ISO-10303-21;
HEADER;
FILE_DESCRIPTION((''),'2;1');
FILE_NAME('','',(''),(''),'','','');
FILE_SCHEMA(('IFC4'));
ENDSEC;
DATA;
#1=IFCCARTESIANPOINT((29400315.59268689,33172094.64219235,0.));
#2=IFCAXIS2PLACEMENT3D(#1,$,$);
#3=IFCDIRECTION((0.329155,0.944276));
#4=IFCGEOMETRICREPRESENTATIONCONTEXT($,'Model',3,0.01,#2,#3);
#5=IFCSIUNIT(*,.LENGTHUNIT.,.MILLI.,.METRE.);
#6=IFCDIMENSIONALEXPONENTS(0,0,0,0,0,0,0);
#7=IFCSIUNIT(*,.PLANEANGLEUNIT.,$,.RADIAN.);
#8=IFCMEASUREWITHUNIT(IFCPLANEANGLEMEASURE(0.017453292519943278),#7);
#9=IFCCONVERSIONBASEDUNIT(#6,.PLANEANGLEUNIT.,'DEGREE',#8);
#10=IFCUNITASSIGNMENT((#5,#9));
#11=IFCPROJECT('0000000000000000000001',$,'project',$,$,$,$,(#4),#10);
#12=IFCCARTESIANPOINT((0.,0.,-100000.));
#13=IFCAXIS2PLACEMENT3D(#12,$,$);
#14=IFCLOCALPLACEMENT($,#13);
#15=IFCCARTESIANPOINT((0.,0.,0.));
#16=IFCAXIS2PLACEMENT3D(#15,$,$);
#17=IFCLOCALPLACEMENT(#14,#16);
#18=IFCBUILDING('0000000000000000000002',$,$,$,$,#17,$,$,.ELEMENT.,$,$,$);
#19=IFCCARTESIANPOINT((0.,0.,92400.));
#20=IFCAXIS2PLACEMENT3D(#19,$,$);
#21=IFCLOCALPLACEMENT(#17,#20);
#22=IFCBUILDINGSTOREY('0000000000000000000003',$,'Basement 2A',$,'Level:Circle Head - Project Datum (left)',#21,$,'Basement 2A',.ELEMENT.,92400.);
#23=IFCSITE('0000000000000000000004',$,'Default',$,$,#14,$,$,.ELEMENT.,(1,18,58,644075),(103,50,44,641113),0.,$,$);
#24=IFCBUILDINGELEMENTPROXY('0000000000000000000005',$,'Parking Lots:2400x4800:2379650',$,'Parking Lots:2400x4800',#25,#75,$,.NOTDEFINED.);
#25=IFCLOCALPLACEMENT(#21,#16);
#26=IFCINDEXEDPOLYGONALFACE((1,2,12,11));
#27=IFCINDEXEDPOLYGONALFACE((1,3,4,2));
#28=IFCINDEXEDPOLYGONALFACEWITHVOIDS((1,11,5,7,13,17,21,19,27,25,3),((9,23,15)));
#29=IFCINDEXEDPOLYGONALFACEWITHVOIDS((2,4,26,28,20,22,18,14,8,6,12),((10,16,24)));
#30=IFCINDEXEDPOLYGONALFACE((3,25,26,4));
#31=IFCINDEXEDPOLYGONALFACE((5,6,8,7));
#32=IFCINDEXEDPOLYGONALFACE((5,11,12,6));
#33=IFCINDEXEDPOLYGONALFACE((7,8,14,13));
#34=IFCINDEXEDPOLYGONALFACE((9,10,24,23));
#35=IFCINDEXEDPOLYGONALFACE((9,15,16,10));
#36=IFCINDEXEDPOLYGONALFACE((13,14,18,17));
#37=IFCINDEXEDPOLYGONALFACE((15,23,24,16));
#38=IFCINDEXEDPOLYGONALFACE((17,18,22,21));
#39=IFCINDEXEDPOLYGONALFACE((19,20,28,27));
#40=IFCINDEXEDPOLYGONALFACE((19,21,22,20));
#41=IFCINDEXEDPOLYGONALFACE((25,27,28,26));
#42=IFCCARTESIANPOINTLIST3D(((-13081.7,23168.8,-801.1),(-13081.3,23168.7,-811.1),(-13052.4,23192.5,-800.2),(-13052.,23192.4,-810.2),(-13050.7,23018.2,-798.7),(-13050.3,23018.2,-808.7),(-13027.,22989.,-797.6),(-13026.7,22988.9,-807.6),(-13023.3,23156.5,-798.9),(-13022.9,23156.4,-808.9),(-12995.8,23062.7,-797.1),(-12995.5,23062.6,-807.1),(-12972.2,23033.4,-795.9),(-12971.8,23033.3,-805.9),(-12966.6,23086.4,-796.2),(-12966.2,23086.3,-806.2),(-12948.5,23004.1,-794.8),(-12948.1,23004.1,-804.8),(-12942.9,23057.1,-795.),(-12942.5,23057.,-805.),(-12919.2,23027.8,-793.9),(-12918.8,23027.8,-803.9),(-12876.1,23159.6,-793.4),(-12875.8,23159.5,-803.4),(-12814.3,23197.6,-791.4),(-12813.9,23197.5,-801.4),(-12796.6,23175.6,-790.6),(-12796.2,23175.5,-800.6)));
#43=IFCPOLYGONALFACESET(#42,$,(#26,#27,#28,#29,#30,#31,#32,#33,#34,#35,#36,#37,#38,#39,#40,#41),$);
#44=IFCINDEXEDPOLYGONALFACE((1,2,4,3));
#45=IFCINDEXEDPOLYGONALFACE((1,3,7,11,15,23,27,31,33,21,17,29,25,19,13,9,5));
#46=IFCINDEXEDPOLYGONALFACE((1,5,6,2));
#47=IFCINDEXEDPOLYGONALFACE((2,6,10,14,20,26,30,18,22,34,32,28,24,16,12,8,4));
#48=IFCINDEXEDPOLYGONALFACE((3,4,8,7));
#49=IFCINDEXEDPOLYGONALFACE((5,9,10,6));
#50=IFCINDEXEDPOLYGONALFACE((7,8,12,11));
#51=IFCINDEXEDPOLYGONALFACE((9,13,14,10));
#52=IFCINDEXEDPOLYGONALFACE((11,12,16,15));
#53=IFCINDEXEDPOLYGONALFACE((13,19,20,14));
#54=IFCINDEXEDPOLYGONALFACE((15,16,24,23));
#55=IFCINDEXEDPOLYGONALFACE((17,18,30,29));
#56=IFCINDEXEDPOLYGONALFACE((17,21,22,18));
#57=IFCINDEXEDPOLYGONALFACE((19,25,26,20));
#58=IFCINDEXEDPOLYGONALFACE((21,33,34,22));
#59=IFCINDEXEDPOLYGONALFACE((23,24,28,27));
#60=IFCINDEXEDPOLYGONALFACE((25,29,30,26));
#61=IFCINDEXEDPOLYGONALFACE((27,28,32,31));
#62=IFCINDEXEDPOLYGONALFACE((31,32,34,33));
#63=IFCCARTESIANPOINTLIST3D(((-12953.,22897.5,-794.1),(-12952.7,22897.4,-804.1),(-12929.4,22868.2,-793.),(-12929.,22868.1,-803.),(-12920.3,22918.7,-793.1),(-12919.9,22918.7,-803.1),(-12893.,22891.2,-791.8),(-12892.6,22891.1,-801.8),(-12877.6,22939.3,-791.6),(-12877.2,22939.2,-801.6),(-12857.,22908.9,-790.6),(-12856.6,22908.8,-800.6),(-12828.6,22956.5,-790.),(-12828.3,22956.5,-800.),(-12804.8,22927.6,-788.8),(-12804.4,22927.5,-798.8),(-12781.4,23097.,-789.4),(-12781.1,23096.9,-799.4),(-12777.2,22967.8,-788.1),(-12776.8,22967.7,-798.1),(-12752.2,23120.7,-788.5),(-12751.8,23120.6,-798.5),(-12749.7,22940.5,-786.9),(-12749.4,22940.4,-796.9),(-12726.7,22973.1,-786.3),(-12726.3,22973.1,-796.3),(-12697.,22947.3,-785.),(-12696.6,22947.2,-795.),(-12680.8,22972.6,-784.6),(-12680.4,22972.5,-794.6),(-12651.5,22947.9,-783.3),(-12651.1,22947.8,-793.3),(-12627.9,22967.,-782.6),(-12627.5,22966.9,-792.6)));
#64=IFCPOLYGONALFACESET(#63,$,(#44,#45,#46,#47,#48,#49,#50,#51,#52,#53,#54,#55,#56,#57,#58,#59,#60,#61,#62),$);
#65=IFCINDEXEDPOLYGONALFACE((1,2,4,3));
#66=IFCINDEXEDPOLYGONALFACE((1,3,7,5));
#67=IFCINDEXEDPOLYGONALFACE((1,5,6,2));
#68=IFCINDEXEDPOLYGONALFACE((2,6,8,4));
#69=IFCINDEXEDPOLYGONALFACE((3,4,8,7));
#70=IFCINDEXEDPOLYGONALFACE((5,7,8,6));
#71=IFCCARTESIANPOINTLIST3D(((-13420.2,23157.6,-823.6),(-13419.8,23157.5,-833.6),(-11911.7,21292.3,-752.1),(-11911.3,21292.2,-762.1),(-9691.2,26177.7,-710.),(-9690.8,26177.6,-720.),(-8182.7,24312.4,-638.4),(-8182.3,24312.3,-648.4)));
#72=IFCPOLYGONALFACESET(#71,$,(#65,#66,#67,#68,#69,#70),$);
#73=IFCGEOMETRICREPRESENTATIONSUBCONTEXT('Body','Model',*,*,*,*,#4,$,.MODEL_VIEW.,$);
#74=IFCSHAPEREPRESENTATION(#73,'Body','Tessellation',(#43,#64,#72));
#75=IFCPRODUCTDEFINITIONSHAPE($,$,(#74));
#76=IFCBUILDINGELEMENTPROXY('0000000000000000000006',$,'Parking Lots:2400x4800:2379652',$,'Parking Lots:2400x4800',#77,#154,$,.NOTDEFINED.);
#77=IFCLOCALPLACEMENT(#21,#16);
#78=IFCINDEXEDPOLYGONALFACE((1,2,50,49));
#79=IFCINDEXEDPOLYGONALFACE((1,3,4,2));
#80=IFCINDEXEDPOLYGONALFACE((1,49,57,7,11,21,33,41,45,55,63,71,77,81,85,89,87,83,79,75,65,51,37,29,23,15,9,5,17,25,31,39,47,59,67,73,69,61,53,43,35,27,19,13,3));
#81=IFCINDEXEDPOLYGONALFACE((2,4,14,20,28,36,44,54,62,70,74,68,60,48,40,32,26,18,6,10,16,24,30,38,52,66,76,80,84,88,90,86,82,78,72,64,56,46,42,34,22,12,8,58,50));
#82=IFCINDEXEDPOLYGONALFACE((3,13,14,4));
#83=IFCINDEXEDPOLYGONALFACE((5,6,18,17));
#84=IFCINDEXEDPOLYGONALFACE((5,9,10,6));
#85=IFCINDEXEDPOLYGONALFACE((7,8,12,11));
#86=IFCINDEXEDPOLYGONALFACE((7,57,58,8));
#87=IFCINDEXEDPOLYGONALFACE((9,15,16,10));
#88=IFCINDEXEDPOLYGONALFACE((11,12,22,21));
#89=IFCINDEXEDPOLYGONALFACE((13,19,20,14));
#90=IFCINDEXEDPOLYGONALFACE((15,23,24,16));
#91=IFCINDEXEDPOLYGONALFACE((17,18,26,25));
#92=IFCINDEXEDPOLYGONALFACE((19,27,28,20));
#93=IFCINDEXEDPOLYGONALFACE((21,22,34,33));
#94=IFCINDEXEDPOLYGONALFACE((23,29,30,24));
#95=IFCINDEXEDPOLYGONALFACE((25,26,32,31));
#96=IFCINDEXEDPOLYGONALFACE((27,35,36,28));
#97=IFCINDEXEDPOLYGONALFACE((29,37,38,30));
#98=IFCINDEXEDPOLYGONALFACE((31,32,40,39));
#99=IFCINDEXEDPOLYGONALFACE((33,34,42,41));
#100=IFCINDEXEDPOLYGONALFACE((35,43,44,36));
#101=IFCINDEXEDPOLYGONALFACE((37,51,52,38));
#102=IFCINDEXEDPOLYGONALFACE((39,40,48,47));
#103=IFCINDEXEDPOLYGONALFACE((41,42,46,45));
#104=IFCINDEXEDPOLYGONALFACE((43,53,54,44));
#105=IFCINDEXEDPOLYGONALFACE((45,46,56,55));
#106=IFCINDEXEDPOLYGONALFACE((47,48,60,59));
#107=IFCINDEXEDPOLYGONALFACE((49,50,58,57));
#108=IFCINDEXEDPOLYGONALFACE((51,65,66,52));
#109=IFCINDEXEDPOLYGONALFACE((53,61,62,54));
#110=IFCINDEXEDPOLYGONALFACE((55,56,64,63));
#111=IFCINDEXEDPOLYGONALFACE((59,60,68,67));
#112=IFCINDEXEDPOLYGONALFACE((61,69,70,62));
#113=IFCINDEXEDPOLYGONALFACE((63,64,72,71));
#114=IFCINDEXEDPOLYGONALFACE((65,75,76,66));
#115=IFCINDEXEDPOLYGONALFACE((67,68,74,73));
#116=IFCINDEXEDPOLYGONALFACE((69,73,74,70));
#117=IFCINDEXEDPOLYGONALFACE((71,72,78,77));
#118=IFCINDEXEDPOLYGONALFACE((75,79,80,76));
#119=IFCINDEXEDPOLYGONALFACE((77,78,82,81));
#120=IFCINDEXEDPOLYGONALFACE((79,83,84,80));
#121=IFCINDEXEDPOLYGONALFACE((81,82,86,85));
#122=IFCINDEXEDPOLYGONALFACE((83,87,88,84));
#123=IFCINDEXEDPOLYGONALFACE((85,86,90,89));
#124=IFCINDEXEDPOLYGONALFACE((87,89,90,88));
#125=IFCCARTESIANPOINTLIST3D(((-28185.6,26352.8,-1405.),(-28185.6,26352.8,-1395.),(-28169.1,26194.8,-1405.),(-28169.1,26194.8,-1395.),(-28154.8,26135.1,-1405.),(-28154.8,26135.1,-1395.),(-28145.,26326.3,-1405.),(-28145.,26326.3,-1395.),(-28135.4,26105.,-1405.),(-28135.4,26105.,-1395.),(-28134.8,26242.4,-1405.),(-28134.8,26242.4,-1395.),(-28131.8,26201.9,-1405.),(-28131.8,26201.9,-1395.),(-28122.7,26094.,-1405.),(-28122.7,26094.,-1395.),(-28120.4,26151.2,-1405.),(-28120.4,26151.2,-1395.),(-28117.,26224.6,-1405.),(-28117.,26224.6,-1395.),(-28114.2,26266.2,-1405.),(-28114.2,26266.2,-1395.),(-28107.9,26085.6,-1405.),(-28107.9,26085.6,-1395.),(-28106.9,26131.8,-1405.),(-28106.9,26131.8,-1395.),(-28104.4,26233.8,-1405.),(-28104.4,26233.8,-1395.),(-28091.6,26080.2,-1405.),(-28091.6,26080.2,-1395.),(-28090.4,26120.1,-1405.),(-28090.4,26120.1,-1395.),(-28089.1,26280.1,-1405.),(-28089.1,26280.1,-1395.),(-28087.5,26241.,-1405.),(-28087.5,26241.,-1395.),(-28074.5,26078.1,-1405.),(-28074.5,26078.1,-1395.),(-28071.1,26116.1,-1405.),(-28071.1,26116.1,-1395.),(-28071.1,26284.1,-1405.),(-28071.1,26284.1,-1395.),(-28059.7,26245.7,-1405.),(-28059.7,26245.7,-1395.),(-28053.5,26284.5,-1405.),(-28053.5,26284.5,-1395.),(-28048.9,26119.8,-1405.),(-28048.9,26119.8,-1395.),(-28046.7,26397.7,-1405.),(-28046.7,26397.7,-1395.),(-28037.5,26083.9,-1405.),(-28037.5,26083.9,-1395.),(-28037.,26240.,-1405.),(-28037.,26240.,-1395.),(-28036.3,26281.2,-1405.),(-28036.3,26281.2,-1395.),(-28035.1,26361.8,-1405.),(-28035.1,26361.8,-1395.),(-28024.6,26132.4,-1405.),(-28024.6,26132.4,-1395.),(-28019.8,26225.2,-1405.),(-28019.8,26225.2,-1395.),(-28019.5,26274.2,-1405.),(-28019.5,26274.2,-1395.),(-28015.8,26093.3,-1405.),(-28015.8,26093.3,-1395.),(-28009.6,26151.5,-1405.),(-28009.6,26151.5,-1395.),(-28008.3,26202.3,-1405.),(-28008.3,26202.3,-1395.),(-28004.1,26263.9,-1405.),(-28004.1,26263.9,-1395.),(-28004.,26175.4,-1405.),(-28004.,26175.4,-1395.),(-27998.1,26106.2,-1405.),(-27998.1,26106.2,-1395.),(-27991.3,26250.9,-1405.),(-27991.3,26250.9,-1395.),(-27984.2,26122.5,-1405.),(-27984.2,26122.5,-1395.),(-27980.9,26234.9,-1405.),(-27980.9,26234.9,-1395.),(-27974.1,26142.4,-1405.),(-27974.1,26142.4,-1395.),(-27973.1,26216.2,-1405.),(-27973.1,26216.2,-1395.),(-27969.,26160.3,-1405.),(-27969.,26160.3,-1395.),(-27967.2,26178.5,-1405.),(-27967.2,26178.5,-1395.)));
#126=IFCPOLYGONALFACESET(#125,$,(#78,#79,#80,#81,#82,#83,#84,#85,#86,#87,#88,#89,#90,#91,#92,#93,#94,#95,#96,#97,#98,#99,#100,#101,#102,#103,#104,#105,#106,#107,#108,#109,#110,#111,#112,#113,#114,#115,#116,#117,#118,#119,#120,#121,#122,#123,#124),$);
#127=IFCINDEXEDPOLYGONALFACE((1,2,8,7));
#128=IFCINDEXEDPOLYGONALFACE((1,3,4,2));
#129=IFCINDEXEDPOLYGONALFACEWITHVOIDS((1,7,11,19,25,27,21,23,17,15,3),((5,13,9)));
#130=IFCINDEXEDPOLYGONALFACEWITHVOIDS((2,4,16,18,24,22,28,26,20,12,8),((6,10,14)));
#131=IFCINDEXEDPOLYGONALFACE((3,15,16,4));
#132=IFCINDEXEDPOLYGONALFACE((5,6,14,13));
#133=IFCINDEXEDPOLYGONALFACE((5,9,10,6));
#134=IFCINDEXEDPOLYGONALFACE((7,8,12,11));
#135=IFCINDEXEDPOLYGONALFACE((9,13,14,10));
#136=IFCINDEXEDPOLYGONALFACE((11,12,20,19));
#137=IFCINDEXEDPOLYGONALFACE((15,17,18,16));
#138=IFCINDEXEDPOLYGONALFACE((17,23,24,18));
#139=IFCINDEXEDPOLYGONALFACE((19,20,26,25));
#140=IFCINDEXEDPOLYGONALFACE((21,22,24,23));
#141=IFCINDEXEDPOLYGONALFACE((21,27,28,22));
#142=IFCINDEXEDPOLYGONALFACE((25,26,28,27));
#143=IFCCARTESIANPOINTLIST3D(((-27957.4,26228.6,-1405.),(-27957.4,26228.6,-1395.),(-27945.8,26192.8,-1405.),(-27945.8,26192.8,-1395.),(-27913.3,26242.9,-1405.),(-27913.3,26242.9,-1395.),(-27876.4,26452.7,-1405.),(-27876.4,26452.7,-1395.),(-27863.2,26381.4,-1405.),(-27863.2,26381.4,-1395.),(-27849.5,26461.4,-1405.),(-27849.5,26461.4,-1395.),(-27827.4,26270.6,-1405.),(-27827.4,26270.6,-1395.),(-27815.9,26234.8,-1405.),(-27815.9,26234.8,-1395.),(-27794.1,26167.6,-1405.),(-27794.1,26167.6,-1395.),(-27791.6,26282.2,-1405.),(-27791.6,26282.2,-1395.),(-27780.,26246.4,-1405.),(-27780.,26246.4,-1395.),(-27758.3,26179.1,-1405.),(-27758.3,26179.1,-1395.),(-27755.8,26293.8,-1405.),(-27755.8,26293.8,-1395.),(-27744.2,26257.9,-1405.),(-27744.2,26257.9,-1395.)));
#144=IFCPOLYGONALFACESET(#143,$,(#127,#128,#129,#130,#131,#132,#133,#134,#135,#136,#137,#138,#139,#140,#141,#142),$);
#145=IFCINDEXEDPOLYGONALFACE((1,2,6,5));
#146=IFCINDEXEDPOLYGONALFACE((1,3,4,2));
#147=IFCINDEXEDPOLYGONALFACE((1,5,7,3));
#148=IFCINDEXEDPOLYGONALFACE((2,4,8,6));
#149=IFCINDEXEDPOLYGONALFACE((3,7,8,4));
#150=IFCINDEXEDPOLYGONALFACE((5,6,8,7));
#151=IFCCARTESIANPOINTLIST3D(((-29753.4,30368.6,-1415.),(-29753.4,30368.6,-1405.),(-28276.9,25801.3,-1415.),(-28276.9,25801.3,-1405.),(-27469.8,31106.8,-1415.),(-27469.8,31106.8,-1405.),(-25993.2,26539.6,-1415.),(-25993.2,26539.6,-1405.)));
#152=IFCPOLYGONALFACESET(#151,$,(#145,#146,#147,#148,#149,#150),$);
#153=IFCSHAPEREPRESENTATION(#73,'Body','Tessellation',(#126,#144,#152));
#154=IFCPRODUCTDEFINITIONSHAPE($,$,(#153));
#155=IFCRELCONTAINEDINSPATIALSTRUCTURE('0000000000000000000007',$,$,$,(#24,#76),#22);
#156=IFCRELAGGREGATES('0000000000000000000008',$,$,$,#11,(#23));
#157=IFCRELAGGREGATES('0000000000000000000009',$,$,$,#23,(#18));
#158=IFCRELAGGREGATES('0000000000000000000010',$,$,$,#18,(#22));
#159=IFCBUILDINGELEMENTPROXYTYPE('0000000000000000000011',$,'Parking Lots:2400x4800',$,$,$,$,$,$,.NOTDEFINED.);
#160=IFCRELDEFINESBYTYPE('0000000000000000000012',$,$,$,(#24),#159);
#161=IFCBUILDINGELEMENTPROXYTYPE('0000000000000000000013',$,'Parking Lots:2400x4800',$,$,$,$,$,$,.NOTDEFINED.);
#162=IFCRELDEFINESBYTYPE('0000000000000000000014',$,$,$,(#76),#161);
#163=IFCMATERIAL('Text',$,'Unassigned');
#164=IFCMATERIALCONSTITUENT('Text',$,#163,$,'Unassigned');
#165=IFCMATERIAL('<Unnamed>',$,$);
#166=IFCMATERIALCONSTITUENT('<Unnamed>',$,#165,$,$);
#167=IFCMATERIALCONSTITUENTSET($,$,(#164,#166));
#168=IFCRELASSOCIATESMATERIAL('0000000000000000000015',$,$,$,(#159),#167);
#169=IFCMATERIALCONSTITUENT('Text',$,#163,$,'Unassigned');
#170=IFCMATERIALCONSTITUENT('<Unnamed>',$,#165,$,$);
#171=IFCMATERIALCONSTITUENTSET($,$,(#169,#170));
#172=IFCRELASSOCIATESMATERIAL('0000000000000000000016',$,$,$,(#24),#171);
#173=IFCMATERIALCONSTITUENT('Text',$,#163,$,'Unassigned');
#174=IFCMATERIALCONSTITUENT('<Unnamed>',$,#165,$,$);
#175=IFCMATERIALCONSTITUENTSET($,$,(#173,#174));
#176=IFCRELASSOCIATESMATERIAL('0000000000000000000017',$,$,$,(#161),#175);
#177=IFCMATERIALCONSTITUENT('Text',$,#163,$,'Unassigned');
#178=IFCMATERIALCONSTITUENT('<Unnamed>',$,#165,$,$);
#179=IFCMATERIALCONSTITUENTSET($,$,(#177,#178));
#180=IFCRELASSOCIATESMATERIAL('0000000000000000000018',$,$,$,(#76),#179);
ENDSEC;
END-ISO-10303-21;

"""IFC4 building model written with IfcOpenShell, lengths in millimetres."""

from ifc_helpers import new_model, entity, si_unit, converted_unit, direction, frame, origin, place, context, subcontext, project, spatial, indexed_curve, outline, extrude, source, transform, mapped, material, constituent, constituent_set, type_object, type_shapes, element, save


model = new_model("IFC4")

# Units and contexts
model_context = context("Model", 3, precision=0.01, world=frame((29400315.59268689, 33172094.64219235, 0.0)), true_north=direction((0.329155, 0.944276)))
body_context = subcontext(model_context, "Body", "Model", "MODEL_VIEW")
ifc_project = project(units=[si_unit("LENGTHUNIT", "METRE", prefix="MILLI"), converted_unit("PLANEANGLEUNIT", "DEGREE", entity("IfcPlaneAngleMeasure", 0.017453292519943278), si_unit("PLANEANGLEUNIT", "RADIAN"), dimensions=[0, 0, 0, 0, 0, 0, 0])], contexts=[model_context])

# Site, building, storey
site_placement = place(None, frame((0.0, 0.0, -100000.0)))
site = spatial("IfcSite", under=ifc_project, at=site_placement, Name="Default", CompositionType="ELEMENT", RefLatitude=(1, 18, 58, 644075), RefLongitude=(103, 50, 44, 641113), RefElevation=0.0)
building_placement = place(site_placement, origin())
building = spatial("IfcBuilding", under=site, at=building_placement, CompositionType="ELEMENT")
storey_placement = place(building_placement, frame((0.0, 0.0, 92400.0)))
storey = spatial("IfcBuildingStorey", under=building, at=storey_placement, Name="Basement 2A", ObjectType="Level:Circle Head - Project Datum (left)", LongName="Basement 2A", CompositionType="ELEMENT", Elevation=92400.0)

# Building element proxies
ifc_material_1 = material(Name="Text", Category="Unassigned")
ifc_constituent_1 = constituent(ifc_material_1, Name="Text", Category="Unassigned")
ifc_material_2 = material(Name="<Unnamed>")
ifc_constituent_2 = constituent(ifc_material_2, Name="<Unnamed>")
ifc_constituent_set_1 = constituent_set(constituents=[ifc_constituent_1, ifc_constituent_2])
ifc_constituent_3 = constituent(ifc_material_1, Name="Text", Category="Unassigned")
ifc_constituent_4 = constituent(ifc_material_2, Name="<Unnamed>")
ifc_constituent_set_2 = constituent_set(constituents=[ifc_constituent_3, ifc_constituent_4])
building_element_proxy_type_1 = type_object("IfcBuildingElementProxyType", Name="Parking Lots:2400x4800", PredefinedType="NOTDEFINED", material=ifc_constituent_set_2)
shared_shape_1 = source(origin(), body_context, "Body", "SweptSolid", [
    extrude(outline(indexed_curve([(-3.4, -109.2), (34.2, -109.2), (34.2, -38.5), (71.9, -38.5), (71.9, -0.9), (34.2, -0.9), (34.2, 187.5), (6.0, 187.5), (-140.0, -0.9), (-140.0, -38.5), (-3.4, -38.5), (-3.4, -109.2)], self_intersect=False), holes=[indexed_curve([(-3.4, -0.9), (-93.6, -0.9), (-3.4, 115.5), (-3.4, -0.9)], self_intersect=False)]), frame((344.7, -4490.8, 10.0)), (0.0, 0.0, 1.0), 10.0),
    extrude(outline(indexed_curve([(-101.8, -99.3), (-101.8, -137.0), (96.0, -137.0), (96.0, -106.5), (67.8, -70.9), (39.9, -25.5), (15.2, 25.4), (-3.1, 77.8), (-12.1, 116.9), (-17.1, 159.7), (-54.7, 159.7), (-50.7, 120.8), (-39.8, 74.7), (-22.3, 25.8), (1.3, -21.4), (29.0, -64.0), (58.3, -99.3), (-101.8, -99.3)], self_intersect=False)), frame((551.4, -4440.3, 10.0), z_axis=(0.0, 0.0, -1.0), x_axis=(1.0, 0.0, 0.0)), (0.0, 0.0, -1.0), 10.0),
    extrude(outline(indexed_curve([(-1200.0, -2400.0), (1200.0, -2400.0), (1200.0, 2400.0), (-1200.0, 2400.0), (-1200.0, -2400.0)], self_intersect=False)), frame((1200.0, -2400.0, 0.0), z_axis=(0.0, 0.0, 1.0), x_axis=(-1.0, 0.0, 0.0)), (0.0, 0.0, 1.0), 10.0),
])
type_shapes(building_element_proxy_type_1, [shared_shape_1])
proxy_1_placement = place(storey_placement, frame((-9690.8, 26177.6, -720.0), z_axis=(-0.037166, 0.008281, 0.999275), x_axis=(0.628546, -0.7772, 0.029818)))
element("IfcBuildingElementProxy", 1, at=proxy_1_placement, inside=storey, type_object=building_element_proxy_type_1, material=ifc_constituent_set_1, Name="Parking Lots:2400x4800:2379650", ObjectType="Parking Lots:2400x4800", PredefinedType="NOTDEFINED", context=body_context, shape_type="MappedRepresentation", body=[
    mapped(shared_shape_1, transform((0.0, 0.0, 0.0), scale=1.0)),
])
ifc_constituent_5 = constituent(ifc_material_1, Name="Text", Category="Unassigned")
ifc_constituent_6 = constituent(ifc_material_2, Name="<Unnamed>")
ifc_constituent_set_3 = constituent_set(constituents=[ifc_constituent_5, ifc_constituent_6])
ifc_constituent_7 = constituent(ifc_material_1, Name="Text", Category="Unassigned")
ifc_constituent_8 = constituent(ifc_material_2, Name="<Unnamed>")
ifc_constituent_set_4 = constituent_set(constituents=[ifc_constituent_7, ifc_constituent_8])
building_element_proxy_type_2 = type_object("IfcBuildingElementProxyType", Name="Parking Lots:2400x4800", PredefinedType="NOTDEFINED", material=ifc_constituent_set_4)
shared_shape_2 = source(origin(), body_context, "Body", "SweptSolid", [
    extrude(outline(indexed_curve([(1.4, -113.1), (37.2, -113.1), (53.4, -108.4), (68.5, -100.5), (81.8, -89.8), (92.9, -76.5), (108.0, -42.2), (111.8, -18.9), (110.6, 3.0), (104.4, 23.5), (93.2, 42.7), (80.9, 56.7), (66.6, 68.1), (31.7, 83.5), (11.7, 87.1), (-7.3, 87.1), (-25.2, 83.4), (-42.2, 76.0), (-57.1, 65.7), (-69.2, 53.0), (-78.5, 38.0), (-84.8, 20.7), (-86.8, -7.9), (-77.9, -38.1), (-154.0, -1.2), (-124.3, 110.4), (-160.7, 120.1), (-198.2, -21.0), (-56.5, -92.8), (-42.3, -57.6), (-53.3, -32.8), (-54.2, -17.2), (-51.1, 0.9), (-40.0, 26.8), (-23.0, 42.8), (-1.2, 49.2), (24.3, 46.5), (49.2, 35.5), (66.3, 17.9), (74.2, -5.1), (71.6, -32.4), (62.8, -53.0), (48.9, -67.1), (30.2, -74.6), (6.6, -75.5), (1.4, -113.1)], self_intersect=False)), frame((327.7, -4489.5, 10.0), z_axis=(0.0, 0.0, 1.0), x_axis=(0.256974, -0.966418, 0.0)), (0.0, 0.0, 1.0), 10.0),
    extrude(outline(indexed_curve([(-3.4, -109.2), (34.2, -109.2), (34.2, -38.5), (71.9, -38.5), (71.9, -0.9), (34.2, -0.9), (34.2, 187.5), (6.0, 187.5), (-140.0, -0.9), (-140.0, -38.5), (-3.4, -38.5), (-3.4, -109.2)], self_intersect=False), holes=[indexed_curve([(-3.4, -0.9), (-93.6, -0.9), (-3.4, 115.5), (-3.4, -0.9)], self_intersect=False)]), frame((575.4, -4490.8, 10.0)), (0.0, 0.0, 1.0), 10.0),
    extrude(outline(indexed_curve([(-1200.0, -2400.0), (1200.0, -2400.0), (1200.0, 2400.0), (-1200.0, 2400.0), (-1200.0, -2400.0)], self_intersect=False)), frame((1200.0, -2400.0, 0.0), z_axis=(0.0, 0.0, 1.0), x_axis=(-1.0, 0.0, 0.0)), (0.0, 0.0, 1.0), 10.0),
])
type_shapes(building_element_proxy_type_2, [shared_shape_2])
proxy_2_placement = place(storey_placement, frame((-29753.4, 30368.6, -1415.0), z_axis=(0.0, 0.0, 1.0), x_axis=(0.951511, 0.307614, 0.0)))
element("IfcBuildingElementProxy", 2, at=proxy_2_placement, inside=storey, type_object=building_element_proxy_type_2, material=ifc_constituent_set_3, Name="Parking Lots:2400x4800:2379652", ObjectType="Parking Lots:2400x4800", PredefinedType="NOTDEFINED", context=body_context, shape_type="MappedRepresentation", body=[
    mapped(shared_shape_2, transform((0.0, 0.0, 0.0), scale=1.0)),
])

save(model, "model.ifc")
